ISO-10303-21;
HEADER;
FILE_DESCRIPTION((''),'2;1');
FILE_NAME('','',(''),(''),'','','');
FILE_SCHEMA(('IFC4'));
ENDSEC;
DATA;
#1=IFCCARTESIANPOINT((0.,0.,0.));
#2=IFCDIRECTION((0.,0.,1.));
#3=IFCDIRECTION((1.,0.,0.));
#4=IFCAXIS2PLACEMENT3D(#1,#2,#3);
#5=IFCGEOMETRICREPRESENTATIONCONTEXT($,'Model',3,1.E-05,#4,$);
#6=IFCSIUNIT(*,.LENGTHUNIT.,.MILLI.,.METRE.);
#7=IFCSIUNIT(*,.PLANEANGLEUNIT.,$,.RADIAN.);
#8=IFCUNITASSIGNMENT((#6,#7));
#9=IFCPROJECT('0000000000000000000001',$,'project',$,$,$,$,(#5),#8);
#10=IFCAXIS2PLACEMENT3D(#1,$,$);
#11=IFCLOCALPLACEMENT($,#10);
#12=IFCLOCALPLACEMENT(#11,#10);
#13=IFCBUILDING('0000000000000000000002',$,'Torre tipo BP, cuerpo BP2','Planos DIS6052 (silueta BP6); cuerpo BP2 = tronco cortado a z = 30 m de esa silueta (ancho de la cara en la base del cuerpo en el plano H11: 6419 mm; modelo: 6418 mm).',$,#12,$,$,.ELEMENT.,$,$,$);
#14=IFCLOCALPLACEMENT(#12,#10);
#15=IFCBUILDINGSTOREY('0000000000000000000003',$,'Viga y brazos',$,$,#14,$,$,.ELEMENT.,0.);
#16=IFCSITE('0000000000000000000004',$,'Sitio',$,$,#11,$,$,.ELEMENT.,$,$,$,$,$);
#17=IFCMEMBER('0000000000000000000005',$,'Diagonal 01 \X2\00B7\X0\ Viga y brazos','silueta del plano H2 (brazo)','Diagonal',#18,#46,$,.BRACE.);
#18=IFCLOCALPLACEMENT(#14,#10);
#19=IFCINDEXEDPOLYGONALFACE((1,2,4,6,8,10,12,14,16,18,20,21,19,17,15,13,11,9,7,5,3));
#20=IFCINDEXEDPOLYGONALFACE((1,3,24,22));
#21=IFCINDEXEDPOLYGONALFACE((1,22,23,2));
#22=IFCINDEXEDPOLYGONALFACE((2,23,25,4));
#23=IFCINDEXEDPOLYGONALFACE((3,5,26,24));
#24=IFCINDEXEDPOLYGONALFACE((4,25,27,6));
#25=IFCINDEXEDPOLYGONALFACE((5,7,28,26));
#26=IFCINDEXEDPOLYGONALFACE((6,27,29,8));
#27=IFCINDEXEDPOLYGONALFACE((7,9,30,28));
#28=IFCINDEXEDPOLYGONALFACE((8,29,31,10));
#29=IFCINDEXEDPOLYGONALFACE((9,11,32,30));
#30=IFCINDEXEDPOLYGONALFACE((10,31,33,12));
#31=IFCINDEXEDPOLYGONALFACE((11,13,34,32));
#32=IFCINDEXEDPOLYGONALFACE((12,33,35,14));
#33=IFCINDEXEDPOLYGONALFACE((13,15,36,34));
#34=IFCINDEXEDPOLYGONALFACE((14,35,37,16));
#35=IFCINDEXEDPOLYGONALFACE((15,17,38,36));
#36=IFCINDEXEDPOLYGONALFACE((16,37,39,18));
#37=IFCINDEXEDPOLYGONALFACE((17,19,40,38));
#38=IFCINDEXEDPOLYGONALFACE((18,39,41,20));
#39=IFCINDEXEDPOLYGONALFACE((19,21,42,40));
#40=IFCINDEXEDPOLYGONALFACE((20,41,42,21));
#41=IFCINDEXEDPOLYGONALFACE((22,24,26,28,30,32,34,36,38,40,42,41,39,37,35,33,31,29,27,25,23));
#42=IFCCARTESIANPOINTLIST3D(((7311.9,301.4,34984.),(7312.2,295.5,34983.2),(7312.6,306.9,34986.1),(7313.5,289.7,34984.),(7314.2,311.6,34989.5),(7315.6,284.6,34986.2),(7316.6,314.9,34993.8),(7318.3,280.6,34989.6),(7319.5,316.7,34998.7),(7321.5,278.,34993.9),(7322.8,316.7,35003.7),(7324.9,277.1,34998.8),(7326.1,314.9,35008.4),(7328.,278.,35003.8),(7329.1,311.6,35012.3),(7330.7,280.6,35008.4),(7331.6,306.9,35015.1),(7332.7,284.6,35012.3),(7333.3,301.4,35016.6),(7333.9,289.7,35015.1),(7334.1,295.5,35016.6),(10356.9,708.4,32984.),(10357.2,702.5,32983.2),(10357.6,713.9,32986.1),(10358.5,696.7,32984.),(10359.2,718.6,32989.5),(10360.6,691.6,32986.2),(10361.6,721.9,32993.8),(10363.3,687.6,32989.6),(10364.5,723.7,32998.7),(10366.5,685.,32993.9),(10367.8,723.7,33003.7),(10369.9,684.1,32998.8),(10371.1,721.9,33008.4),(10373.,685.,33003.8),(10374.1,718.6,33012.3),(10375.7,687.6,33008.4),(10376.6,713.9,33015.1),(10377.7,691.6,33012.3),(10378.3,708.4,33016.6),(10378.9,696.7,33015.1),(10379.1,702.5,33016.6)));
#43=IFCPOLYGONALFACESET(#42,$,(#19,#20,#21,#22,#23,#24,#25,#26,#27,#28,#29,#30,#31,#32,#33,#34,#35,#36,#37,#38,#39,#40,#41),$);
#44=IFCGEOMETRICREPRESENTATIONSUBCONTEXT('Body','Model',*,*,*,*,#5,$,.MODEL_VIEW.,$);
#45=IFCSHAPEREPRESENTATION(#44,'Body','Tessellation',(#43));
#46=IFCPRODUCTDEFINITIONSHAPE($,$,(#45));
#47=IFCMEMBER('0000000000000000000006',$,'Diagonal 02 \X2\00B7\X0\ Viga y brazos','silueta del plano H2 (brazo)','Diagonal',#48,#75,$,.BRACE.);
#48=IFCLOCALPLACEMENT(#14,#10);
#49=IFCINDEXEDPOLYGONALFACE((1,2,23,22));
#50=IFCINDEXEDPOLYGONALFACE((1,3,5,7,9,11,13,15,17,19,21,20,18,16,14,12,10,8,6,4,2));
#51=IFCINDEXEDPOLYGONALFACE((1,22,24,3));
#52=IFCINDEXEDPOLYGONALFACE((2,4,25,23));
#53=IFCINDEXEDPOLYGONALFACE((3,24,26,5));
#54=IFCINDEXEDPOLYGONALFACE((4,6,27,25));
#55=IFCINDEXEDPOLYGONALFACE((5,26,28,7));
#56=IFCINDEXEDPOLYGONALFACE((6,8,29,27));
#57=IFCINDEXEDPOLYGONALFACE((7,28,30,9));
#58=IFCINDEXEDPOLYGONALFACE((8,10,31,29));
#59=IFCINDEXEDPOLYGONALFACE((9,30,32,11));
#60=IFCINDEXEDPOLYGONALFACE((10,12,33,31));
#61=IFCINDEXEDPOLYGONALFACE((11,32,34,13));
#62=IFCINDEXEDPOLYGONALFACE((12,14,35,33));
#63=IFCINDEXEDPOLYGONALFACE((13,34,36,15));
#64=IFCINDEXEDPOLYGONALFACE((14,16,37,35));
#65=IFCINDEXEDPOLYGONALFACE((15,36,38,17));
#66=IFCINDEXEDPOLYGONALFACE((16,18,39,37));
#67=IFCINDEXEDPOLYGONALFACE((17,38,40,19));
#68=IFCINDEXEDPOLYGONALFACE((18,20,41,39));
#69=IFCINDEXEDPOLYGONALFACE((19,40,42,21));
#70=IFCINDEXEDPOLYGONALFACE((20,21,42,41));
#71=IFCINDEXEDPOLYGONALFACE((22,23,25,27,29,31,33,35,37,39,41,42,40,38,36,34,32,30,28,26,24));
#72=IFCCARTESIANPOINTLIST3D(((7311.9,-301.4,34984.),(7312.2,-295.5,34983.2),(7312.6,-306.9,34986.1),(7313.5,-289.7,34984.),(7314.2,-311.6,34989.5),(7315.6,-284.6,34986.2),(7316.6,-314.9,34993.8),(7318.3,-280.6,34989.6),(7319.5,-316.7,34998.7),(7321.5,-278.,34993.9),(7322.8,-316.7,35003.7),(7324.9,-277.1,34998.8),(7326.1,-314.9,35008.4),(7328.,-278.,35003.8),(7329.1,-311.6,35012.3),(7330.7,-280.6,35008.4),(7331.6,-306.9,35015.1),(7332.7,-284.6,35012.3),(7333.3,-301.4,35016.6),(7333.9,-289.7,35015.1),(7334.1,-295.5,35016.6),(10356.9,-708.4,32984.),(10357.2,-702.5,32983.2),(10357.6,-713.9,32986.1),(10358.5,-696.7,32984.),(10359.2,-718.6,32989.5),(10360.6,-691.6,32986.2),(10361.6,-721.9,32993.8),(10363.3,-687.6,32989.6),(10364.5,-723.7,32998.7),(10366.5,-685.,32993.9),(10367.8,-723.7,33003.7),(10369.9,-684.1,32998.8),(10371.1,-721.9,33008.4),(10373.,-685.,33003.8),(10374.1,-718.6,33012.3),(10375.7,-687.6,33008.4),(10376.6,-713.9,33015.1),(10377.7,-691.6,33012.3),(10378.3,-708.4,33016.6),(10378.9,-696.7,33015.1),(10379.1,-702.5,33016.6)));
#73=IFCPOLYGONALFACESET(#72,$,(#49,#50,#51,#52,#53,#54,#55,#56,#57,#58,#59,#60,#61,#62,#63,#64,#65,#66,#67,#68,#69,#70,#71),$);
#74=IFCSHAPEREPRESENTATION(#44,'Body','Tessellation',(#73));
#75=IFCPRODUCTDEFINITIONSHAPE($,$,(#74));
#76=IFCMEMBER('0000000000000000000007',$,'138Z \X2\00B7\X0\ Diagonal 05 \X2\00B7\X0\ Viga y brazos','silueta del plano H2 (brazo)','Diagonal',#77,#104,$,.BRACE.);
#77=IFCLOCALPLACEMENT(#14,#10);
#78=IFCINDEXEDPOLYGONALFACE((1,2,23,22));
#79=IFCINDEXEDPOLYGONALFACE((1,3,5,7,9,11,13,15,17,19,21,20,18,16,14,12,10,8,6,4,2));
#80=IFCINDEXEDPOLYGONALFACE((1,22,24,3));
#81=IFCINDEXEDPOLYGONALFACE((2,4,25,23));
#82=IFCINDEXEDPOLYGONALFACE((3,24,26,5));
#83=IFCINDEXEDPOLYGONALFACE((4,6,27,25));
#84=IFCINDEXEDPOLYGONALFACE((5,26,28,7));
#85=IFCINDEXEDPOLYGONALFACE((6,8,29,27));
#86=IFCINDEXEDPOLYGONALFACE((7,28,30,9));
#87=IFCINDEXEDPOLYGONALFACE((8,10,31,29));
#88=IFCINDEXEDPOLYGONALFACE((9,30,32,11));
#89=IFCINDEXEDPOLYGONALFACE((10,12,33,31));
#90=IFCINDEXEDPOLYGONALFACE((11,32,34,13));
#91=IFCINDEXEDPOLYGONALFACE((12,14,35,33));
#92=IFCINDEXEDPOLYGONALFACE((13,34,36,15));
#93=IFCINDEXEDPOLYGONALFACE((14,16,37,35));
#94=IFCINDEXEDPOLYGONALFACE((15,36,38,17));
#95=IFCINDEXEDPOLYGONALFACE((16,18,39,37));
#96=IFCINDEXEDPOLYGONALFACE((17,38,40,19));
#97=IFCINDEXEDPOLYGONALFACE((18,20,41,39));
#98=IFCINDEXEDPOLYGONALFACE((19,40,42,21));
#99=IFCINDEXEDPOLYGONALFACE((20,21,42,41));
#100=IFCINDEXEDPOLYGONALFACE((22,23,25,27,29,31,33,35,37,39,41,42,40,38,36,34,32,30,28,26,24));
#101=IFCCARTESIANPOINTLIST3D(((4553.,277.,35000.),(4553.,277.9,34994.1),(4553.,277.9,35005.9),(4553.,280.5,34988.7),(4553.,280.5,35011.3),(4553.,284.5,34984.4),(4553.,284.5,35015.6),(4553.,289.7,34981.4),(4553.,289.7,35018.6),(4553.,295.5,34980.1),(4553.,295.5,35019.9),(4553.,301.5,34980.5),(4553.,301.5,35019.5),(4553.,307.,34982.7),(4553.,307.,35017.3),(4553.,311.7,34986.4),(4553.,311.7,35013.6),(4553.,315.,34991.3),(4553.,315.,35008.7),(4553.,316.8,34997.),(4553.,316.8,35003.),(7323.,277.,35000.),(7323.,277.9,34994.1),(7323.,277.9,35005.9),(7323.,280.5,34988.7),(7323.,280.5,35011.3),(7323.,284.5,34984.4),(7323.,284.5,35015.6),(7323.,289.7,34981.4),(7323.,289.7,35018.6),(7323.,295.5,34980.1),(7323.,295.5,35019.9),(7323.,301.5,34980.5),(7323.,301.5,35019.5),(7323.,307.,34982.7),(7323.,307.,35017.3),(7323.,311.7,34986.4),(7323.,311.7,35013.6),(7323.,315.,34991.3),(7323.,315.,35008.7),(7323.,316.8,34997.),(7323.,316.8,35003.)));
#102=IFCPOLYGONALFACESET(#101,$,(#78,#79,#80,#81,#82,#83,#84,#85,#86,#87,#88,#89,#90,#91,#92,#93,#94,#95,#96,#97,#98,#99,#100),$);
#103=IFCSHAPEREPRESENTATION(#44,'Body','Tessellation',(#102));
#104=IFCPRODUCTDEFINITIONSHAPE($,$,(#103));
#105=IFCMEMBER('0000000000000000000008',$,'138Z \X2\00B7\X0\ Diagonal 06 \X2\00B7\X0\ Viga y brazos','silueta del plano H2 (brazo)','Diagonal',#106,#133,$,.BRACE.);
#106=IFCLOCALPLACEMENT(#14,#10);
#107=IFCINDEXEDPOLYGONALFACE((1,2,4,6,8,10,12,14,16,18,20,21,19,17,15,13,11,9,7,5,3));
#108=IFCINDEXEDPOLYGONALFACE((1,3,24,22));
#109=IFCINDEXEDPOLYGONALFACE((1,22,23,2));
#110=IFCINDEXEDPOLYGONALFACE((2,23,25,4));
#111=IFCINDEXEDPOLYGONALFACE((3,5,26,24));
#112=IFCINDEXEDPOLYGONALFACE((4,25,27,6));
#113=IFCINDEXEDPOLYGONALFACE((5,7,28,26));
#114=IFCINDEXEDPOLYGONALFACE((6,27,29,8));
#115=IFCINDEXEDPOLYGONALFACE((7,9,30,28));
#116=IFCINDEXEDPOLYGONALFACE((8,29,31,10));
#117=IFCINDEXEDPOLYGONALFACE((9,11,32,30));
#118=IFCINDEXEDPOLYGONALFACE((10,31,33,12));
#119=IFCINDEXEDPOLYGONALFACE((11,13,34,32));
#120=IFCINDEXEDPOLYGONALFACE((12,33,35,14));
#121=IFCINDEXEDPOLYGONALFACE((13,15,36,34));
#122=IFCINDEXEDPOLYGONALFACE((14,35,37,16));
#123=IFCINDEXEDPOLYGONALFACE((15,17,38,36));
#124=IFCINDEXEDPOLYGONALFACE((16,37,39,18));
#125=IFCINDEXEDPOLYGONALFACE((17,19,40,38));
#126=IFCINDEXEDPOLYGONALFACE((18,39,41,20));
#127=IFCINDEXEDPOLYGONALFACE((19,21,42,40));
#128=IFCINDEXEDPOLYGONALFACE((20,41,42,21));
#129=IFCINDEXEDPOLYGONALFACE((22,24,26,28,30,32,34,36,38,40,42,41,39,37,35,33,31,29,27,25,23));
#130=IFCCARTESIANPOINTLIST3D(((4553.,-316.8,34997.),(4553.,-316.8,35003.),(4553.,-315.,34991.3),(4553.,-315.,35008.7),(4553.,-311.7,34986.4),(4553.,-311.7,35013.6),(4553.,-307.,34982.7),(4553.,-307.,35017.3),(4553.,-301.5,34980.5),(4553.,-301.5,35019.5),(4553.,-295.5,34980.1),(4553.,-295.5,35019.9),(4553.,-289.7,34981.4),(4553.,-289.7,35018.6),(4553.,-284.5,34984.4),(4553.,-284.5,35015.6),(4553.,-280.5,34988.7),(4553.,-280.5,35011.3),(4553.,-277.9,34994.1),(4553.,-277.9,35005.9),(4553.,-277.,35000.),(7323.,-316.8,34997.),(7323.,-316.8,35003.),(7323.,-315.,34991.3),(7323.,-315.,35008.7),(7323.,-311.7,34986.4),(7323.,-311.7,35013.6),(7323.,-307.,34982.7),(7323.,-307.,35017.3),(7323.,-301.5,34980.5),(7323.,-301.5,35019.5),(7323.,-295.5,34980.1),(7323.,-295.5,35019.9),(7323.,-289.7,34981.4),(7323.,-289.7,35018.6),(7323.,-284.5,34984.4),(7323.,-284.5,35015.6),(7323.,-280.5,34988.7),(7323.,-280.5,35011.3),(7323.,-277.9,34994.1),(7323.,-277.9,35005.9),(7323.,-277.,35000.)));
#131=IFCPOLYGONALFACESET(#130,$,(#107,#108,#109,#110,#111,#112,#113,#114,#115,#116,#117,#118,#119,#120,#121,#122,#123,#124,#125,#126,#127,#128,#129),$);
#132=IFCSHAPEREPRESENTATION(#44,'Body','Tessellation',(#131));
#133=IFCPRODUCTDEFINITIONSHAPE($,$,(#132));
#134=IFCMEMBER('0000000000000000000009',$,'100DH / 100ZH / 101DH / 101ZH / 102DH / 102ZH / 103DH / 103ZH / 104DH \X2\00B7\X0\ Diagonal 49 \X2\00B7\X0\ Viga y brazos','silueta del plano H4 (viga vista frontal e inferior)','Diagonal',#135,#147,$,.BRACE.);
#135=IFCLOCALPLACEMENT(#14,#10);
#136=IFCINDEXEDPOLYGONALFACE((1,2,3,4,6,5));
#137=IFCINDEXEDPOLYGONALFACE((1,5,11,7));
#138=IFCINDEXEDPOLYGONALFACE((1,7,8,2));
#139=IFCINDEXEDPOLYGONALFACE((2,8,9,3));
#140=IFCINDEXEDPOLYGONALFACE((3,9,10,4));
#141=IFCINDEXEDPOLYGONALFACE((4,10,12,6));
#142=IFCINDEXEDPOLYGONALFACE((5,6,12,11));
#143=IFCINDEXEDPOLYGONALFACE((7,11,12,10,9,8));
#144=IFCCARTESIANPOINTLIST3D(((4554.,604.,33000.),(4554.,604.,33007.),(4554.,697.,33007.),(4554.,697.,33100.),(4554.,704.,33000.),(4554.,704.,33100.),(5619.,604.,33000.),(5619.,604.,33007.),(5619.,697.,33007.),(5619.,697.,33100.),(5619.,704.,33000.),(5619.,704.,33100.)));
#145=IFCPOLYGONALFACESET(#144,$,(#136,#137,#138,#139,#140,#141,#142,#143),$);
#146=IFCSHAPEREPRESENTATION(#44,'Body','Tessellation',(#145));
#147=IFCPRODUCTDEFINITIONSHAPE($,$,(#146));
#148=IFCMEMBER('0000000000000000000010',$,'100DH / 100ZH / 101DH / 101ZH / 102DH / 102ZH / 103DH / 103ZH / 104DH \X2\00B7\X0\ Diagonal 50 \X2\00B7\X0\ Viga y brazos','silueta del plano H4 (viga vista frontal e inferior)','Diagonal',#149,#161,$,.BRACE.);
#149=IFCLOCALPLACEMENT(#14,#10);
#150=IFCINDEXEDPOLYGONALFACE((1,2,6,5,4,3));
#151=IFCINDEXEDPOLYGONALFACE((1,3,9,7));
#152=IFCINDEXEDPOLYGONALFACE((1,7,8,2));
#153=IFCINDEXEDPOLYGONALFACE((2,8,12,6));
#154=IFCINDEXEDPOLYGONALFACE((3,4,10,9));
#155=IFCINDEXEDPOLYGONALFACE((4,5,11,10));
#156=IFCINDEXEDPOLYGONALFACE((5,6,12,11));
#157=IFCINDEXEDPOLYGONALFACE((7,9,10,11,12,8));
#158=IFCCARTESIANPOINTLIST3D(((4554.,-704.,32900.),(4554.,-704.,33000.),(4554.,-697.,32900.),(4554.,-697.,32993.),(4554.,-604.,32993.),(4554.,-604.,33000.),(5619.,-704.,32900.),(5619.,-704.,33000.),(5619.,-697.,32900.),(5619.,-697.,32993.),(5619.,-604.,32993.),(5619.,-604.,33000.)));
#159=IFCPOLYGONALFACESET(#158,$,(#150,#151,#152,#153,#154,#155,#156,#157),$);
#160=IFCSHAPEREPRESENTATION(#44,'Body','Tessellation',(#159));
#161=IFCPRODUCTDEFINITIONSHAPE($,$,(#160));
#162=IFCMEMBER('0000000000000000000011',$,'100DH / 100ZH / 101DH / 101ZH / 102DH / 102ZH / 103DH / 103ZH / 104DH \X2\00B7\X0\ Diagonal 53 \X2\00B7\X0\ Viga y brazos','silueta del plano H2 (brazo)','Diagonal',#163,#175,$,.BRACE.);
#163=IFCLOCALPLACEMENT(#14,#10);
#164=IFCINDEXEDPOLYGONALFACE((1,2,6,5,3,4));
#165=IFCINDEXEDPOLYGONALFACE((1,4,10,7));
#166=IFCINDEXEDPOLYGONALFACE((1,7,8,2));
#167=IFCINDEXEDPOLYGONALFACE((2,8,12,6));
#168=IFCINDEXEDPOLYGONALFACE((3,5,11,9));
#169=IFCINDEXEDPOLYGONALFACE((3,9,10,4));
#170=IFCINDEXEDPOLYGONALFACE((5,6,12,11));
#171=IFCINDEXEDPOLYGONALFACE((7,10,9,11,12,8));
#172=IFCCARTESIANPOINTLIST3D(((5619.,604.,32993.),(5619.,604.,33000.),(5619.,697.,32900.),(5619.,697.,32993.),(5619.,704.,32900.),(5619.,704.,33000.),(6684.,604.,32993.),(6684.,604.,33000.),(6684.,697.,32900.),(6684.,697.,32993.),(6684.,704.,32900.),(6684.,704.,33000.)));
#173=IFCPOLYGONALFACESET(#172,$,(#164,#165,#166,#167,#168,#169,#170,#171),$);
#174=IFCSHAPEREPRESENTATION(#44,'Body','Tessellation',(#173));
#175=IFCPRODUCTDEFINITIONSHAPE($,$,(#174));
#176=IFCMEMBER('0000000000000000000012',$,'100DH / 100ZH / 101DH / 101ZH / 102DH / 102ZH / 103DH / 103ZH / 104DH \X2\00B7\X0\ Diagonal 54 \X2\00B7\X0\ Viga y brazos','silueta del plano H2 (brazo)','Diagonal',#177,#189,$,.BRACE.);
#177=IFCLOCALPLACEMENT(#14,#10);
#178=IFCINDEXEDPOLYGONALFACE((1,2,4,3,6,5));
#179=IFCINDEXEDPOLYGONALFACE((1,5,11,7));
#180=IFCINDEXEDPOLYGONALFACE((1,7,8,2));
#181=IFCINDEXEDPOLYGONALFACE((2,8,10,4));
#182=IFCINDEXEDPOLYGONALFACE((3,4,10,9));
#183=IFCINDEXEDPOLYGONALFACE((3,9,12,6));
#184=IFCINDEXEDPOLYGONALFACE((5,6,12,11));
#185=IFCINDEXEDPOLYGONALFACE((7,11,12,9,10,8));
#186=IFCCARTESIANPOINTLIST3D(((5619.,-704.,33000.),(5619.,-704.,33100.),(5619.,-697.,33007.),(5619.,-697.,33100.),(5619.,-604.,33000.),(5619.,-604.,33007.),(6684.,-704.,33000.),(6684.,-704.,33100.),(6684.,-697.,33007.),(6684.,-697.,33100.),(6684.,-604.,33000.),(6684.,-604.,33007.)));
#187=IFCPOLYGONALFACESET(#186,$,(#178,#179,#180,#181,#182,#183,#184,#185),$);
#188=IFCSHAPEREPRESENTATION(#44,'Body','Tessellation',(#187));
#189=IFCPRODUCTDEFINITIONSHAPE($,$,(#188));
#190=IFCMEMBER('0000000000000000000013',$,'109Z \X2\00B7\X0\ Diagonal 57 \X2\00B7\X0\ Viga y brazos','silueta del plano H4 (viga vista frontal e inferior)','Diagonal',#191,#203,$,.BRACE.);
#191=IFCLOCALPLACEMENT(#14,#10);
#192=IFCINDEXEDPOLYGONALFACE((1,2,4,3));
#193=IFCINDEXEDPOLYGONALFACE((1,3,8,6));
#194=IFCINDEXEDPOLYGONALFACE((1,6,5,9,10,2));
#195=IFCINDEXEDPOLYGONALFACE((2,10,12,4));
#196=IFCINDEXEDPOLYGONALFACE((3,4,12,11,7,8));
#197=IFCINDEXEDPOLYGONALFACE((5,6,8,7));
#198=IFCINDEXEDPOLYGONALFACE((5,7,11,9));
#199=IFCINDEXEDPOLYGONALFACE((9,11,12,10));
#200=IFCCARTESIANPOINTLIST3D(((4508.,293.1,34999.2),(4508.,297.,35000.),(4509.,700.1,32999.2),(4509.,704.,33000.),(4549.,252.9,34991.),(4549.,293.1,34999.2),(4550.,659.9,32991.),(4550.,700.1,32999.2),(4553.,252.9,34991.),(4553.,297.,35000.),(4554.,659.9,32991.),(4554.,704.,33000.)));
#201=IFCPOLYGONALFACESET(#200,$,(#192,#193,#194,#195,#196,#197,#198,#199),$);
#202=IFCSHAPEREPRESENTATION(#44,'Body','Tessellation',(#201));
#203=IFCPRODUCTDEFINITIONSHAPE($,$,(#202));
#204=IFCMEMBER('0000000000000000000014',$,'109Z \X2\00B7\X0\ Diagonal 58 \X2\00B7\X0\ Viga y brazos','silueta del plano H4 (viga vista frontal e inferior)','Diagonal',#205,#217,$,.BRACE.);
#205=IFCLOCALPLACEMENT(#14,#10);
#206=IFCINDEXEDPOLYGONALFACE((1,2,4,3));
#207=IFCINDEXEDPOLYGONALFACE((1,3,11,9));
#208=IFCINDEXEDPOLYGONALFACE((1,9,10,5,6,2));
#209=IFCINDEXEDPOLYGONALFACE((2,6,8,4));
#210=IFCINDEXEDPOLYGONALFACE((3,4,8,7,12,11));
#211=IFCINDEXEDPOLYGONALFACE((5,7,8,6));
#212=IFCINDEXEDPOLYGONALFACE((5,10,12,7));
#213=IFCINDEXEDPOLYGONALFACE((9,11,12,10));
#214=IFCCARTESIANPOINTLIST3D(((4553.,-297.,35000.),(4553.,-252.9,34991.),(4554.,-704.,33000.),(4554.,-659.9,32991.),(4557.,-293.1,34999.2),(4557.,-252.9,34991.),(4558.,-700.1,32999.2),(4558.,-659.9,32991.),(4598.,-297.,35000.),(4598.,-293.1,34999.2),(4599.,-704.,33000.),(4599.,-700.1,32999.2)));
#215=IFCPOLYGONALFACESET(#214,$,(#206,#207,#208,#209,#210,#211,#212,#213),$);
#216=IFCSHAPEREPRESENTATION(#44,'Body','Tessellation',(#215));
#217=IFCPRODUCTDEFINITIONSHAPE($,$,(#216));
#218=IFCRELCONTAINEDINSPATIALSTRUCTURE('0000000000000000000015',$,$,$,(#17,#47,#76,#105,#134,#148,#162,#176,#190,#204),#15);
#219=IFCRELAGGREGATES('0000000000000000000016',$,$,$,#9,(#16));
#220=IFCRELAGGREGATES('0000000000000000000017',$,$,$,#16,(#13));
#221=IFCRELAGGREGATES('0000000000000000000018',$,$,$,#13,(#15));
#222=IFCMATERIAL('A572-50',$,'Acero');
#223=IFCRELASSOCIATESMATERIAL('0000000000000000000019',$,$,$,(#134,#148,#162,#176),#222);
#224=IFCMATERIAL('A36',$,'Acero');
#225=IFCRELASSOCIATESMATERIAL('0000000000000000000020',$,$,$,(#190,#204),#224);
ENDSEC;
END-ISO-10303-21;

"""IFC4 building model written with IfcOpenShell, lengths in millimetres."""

from ifc_helpers import new_model, si_unit, frame, frame_2d, origin, origin_with_axes, place, context, subcontext, project, spatial, circle, l_section, extrude, material, element, save


model = new_model("IFC4")

# Units and contexts
model_context = context("Model", 3, precision=1e-05, world=origin_with_axes())
body_context = subcontext(model_context, "Body", "Model", "MODEL_VIEW")
ifc_project = project(units=[si_unit("LENGTHUNIT", "METRE", prefix="MILLI"), si_unit("PLANEANGLEUNIT", "RADIAN")], contexts=[model_context])

# Site, building, storey
site_placement = place(None, origin())
site = spatial("IfcSite", under=ifc_project, at=site_placement, Name="Sitio", CompositionType="ELEMENT")
building_placement = place(site_placement, origin())
building = spatial("IfcBuilding", under=site, at=building_placement, Name="Torre tipo BP, cuerpo BP2", Description="Planos DIS6052 (silueta BP6); cuerpo BP2 = tronco cortado a z = 30 m de esa silueta (ancho de la cara en la base del cuerpo en el plano H11: 6419 mm; modelo: 6418 mm).", CompositionType="ELEMENT")
storey_placement = place(building_placement, origin())
storey = spatial("IfcBuildingStorey", under=building, at=storey_placement, Name="Viga y brazos", CompositionType="ELEMENT", Elevation=0.0)

# Members
for number, where, z_axis, x_axis, name in (
    (1, (7323.0, 297.0, 35000.0), (0.830664, 0.111028, -0.545592), (0.092801, -0.993817, -0.060953), "Diagonal 01 · Viga y brazos"),
    (2, (7323.0, -297.0, 35000.0), (0.830664, -0.111028, -0.545592), (0.092801, 0.993817, -0.060953), "Diagonal 02 · Viga y brazos"),
):
    element("IfcMember", number, at=place(storey_placement, frame(where, z_axis=z_axis, x_axis=x_axis)), inside=storey, Name=name, Description="silueta del plano H2 (brazo)", ObjectType="Diagonal", PredefinedType="BRACE", context=body_context, shape_type="SweptSolid", body=[
        extrude(circle(Radius=20.0), None, (0.0, 0.0, 1.0), 3665.7),
    ])
for number, where, z_axis, x_axis, name in (
    (3, (7323.0, 297.0, 35000.0), (-1.0, 0.0, 0.0), (0.0, -1.0, 0.0), "138Z · Diagonal 05 · Viga y brazos"),
    (4, (7323.0, -297.0, 35000.0), (-1.0, 0.0, 0.0), (0.0, 1.0, 0.0), "138Z · Diagonal 06 · Viga y brazos"),
):
    element("IfcMember", number, at=place(storey_placement, frame(where, z_axis=z_axis, x_axis=x_axis)), inside=storey, Name=name, Description="silueta del plano H2 (brazo)", ObjectType="Diagonal", PredefinedType="BRACE", context=body_context, shape_type="SweptSolid", body=[
        extrude(circle(Radius=20.0), None, (0.0, 0.0, 1.0), 2770.0),
    ])
ifc_material_1 = material(Name="A572-50", Category="Acero")
for number, where, z_axis, x_axis, name, description in (
    (5, (5619.0, 704.0, 33000.0), (-1.0, 0.0, 0.0), (0.0, -1.0, 0.0), "100DH / 100ZH / 101DH / 101ZH / 102DH / 102ZH / 103DH / 103ZH / 104DH · Diagonal 49 · Viga y brazos", "silueta del plano H4 (viga vista frontal e inferior)"),
    (6, (5619.0, -704.0, 33000.0), (-1.0, 0.0, 0.0), (0.0, 1.0, 0.0), "100DH / 100ZH / 101DH / 101ZH / 102DH / 102ZH / 103DH / 103ZH / 104DH · Diagonal 50 · Viga y brazos", "silueta del plano H4 (viga vista frontal e inferior)"),
    (7, (5619.0, 704.0, 33000.0), (1.0, 0.0, 0.0), (0.0, -1.0, 0.0), "100DH / 100ZH / 101DH / 101ZH / 102DH / 102ZH / 103DH / 103ZH / 104DH · Diagonal 53 · Viga y brazos", "silueta del plano H2 (brazo)"),
    (8, (5619.0, -704.0, 33000.0), (1.0, 0.0, 0.0), (0.0, 1.0, 0.0), "100DH / 100ZH / 101DH / 101ZH / 102DH / 102ZH / 103DH / 103ZH / 104DH · Diagonal 54 · Viga y brazos", "silueta del plano H2 (brazo)"),
):
    element("IfcMember", number, at=place(storey_placement, frame(where, z_axis=z_axis, x_axis=x_axis)), inside=storey, material=ifc_material_1, Name=name, Description=description, ObjectType="Diagonal", PredefinedType="BRACE", context=body_context, shape_type="SweptSolid", body=[
        extrude(l_section(Depth=100.0, Width=100.0, Thickness=7.0, at=frame_2d((50.0, 50.0))), None, (0.0, 0.0, 1.0), 1065.0),
    ])
ifc_material_2 = material(Name="A36", Category="Acero")
for number, where, z_axis, x_axis, name in (
    (9, (4553.0, 297.0, 35000.0), (0.00049, 0.199413, -0.979915), (0.0001, -0.979916, -0.199413), "109Z · Diagonal 57 · Viga y brazos"),
    (10, (4553.0, -297.0, 35000.0), (0.00049, -0.199413, -0.979915), (0.0001, 0.979916, -0.199413), "109Z · Diagonal 58 · Viga y brazos"),
):
    element("IfcMember", number, at=place(storey_placement, frame(where, z_axis=z_axis, x_axis=x_axis)), inside=storey, material=ifc_material_2, Name=name, Description="silueta del plano H4 (viga vista frontal e inferior)", ObjectType="Diagonal", PredefinedType="BRACE", context=body_context, shape_type="SweptSolid", body=[
        extrude(l_section(Depth=45.0, Width=45.0, Thickness=4.0, at=frame_2d((22.5, 22.5))), None, (0.0, 0.0, 1.0), 2041.0),
    ])

save(model, "model.ifc")
